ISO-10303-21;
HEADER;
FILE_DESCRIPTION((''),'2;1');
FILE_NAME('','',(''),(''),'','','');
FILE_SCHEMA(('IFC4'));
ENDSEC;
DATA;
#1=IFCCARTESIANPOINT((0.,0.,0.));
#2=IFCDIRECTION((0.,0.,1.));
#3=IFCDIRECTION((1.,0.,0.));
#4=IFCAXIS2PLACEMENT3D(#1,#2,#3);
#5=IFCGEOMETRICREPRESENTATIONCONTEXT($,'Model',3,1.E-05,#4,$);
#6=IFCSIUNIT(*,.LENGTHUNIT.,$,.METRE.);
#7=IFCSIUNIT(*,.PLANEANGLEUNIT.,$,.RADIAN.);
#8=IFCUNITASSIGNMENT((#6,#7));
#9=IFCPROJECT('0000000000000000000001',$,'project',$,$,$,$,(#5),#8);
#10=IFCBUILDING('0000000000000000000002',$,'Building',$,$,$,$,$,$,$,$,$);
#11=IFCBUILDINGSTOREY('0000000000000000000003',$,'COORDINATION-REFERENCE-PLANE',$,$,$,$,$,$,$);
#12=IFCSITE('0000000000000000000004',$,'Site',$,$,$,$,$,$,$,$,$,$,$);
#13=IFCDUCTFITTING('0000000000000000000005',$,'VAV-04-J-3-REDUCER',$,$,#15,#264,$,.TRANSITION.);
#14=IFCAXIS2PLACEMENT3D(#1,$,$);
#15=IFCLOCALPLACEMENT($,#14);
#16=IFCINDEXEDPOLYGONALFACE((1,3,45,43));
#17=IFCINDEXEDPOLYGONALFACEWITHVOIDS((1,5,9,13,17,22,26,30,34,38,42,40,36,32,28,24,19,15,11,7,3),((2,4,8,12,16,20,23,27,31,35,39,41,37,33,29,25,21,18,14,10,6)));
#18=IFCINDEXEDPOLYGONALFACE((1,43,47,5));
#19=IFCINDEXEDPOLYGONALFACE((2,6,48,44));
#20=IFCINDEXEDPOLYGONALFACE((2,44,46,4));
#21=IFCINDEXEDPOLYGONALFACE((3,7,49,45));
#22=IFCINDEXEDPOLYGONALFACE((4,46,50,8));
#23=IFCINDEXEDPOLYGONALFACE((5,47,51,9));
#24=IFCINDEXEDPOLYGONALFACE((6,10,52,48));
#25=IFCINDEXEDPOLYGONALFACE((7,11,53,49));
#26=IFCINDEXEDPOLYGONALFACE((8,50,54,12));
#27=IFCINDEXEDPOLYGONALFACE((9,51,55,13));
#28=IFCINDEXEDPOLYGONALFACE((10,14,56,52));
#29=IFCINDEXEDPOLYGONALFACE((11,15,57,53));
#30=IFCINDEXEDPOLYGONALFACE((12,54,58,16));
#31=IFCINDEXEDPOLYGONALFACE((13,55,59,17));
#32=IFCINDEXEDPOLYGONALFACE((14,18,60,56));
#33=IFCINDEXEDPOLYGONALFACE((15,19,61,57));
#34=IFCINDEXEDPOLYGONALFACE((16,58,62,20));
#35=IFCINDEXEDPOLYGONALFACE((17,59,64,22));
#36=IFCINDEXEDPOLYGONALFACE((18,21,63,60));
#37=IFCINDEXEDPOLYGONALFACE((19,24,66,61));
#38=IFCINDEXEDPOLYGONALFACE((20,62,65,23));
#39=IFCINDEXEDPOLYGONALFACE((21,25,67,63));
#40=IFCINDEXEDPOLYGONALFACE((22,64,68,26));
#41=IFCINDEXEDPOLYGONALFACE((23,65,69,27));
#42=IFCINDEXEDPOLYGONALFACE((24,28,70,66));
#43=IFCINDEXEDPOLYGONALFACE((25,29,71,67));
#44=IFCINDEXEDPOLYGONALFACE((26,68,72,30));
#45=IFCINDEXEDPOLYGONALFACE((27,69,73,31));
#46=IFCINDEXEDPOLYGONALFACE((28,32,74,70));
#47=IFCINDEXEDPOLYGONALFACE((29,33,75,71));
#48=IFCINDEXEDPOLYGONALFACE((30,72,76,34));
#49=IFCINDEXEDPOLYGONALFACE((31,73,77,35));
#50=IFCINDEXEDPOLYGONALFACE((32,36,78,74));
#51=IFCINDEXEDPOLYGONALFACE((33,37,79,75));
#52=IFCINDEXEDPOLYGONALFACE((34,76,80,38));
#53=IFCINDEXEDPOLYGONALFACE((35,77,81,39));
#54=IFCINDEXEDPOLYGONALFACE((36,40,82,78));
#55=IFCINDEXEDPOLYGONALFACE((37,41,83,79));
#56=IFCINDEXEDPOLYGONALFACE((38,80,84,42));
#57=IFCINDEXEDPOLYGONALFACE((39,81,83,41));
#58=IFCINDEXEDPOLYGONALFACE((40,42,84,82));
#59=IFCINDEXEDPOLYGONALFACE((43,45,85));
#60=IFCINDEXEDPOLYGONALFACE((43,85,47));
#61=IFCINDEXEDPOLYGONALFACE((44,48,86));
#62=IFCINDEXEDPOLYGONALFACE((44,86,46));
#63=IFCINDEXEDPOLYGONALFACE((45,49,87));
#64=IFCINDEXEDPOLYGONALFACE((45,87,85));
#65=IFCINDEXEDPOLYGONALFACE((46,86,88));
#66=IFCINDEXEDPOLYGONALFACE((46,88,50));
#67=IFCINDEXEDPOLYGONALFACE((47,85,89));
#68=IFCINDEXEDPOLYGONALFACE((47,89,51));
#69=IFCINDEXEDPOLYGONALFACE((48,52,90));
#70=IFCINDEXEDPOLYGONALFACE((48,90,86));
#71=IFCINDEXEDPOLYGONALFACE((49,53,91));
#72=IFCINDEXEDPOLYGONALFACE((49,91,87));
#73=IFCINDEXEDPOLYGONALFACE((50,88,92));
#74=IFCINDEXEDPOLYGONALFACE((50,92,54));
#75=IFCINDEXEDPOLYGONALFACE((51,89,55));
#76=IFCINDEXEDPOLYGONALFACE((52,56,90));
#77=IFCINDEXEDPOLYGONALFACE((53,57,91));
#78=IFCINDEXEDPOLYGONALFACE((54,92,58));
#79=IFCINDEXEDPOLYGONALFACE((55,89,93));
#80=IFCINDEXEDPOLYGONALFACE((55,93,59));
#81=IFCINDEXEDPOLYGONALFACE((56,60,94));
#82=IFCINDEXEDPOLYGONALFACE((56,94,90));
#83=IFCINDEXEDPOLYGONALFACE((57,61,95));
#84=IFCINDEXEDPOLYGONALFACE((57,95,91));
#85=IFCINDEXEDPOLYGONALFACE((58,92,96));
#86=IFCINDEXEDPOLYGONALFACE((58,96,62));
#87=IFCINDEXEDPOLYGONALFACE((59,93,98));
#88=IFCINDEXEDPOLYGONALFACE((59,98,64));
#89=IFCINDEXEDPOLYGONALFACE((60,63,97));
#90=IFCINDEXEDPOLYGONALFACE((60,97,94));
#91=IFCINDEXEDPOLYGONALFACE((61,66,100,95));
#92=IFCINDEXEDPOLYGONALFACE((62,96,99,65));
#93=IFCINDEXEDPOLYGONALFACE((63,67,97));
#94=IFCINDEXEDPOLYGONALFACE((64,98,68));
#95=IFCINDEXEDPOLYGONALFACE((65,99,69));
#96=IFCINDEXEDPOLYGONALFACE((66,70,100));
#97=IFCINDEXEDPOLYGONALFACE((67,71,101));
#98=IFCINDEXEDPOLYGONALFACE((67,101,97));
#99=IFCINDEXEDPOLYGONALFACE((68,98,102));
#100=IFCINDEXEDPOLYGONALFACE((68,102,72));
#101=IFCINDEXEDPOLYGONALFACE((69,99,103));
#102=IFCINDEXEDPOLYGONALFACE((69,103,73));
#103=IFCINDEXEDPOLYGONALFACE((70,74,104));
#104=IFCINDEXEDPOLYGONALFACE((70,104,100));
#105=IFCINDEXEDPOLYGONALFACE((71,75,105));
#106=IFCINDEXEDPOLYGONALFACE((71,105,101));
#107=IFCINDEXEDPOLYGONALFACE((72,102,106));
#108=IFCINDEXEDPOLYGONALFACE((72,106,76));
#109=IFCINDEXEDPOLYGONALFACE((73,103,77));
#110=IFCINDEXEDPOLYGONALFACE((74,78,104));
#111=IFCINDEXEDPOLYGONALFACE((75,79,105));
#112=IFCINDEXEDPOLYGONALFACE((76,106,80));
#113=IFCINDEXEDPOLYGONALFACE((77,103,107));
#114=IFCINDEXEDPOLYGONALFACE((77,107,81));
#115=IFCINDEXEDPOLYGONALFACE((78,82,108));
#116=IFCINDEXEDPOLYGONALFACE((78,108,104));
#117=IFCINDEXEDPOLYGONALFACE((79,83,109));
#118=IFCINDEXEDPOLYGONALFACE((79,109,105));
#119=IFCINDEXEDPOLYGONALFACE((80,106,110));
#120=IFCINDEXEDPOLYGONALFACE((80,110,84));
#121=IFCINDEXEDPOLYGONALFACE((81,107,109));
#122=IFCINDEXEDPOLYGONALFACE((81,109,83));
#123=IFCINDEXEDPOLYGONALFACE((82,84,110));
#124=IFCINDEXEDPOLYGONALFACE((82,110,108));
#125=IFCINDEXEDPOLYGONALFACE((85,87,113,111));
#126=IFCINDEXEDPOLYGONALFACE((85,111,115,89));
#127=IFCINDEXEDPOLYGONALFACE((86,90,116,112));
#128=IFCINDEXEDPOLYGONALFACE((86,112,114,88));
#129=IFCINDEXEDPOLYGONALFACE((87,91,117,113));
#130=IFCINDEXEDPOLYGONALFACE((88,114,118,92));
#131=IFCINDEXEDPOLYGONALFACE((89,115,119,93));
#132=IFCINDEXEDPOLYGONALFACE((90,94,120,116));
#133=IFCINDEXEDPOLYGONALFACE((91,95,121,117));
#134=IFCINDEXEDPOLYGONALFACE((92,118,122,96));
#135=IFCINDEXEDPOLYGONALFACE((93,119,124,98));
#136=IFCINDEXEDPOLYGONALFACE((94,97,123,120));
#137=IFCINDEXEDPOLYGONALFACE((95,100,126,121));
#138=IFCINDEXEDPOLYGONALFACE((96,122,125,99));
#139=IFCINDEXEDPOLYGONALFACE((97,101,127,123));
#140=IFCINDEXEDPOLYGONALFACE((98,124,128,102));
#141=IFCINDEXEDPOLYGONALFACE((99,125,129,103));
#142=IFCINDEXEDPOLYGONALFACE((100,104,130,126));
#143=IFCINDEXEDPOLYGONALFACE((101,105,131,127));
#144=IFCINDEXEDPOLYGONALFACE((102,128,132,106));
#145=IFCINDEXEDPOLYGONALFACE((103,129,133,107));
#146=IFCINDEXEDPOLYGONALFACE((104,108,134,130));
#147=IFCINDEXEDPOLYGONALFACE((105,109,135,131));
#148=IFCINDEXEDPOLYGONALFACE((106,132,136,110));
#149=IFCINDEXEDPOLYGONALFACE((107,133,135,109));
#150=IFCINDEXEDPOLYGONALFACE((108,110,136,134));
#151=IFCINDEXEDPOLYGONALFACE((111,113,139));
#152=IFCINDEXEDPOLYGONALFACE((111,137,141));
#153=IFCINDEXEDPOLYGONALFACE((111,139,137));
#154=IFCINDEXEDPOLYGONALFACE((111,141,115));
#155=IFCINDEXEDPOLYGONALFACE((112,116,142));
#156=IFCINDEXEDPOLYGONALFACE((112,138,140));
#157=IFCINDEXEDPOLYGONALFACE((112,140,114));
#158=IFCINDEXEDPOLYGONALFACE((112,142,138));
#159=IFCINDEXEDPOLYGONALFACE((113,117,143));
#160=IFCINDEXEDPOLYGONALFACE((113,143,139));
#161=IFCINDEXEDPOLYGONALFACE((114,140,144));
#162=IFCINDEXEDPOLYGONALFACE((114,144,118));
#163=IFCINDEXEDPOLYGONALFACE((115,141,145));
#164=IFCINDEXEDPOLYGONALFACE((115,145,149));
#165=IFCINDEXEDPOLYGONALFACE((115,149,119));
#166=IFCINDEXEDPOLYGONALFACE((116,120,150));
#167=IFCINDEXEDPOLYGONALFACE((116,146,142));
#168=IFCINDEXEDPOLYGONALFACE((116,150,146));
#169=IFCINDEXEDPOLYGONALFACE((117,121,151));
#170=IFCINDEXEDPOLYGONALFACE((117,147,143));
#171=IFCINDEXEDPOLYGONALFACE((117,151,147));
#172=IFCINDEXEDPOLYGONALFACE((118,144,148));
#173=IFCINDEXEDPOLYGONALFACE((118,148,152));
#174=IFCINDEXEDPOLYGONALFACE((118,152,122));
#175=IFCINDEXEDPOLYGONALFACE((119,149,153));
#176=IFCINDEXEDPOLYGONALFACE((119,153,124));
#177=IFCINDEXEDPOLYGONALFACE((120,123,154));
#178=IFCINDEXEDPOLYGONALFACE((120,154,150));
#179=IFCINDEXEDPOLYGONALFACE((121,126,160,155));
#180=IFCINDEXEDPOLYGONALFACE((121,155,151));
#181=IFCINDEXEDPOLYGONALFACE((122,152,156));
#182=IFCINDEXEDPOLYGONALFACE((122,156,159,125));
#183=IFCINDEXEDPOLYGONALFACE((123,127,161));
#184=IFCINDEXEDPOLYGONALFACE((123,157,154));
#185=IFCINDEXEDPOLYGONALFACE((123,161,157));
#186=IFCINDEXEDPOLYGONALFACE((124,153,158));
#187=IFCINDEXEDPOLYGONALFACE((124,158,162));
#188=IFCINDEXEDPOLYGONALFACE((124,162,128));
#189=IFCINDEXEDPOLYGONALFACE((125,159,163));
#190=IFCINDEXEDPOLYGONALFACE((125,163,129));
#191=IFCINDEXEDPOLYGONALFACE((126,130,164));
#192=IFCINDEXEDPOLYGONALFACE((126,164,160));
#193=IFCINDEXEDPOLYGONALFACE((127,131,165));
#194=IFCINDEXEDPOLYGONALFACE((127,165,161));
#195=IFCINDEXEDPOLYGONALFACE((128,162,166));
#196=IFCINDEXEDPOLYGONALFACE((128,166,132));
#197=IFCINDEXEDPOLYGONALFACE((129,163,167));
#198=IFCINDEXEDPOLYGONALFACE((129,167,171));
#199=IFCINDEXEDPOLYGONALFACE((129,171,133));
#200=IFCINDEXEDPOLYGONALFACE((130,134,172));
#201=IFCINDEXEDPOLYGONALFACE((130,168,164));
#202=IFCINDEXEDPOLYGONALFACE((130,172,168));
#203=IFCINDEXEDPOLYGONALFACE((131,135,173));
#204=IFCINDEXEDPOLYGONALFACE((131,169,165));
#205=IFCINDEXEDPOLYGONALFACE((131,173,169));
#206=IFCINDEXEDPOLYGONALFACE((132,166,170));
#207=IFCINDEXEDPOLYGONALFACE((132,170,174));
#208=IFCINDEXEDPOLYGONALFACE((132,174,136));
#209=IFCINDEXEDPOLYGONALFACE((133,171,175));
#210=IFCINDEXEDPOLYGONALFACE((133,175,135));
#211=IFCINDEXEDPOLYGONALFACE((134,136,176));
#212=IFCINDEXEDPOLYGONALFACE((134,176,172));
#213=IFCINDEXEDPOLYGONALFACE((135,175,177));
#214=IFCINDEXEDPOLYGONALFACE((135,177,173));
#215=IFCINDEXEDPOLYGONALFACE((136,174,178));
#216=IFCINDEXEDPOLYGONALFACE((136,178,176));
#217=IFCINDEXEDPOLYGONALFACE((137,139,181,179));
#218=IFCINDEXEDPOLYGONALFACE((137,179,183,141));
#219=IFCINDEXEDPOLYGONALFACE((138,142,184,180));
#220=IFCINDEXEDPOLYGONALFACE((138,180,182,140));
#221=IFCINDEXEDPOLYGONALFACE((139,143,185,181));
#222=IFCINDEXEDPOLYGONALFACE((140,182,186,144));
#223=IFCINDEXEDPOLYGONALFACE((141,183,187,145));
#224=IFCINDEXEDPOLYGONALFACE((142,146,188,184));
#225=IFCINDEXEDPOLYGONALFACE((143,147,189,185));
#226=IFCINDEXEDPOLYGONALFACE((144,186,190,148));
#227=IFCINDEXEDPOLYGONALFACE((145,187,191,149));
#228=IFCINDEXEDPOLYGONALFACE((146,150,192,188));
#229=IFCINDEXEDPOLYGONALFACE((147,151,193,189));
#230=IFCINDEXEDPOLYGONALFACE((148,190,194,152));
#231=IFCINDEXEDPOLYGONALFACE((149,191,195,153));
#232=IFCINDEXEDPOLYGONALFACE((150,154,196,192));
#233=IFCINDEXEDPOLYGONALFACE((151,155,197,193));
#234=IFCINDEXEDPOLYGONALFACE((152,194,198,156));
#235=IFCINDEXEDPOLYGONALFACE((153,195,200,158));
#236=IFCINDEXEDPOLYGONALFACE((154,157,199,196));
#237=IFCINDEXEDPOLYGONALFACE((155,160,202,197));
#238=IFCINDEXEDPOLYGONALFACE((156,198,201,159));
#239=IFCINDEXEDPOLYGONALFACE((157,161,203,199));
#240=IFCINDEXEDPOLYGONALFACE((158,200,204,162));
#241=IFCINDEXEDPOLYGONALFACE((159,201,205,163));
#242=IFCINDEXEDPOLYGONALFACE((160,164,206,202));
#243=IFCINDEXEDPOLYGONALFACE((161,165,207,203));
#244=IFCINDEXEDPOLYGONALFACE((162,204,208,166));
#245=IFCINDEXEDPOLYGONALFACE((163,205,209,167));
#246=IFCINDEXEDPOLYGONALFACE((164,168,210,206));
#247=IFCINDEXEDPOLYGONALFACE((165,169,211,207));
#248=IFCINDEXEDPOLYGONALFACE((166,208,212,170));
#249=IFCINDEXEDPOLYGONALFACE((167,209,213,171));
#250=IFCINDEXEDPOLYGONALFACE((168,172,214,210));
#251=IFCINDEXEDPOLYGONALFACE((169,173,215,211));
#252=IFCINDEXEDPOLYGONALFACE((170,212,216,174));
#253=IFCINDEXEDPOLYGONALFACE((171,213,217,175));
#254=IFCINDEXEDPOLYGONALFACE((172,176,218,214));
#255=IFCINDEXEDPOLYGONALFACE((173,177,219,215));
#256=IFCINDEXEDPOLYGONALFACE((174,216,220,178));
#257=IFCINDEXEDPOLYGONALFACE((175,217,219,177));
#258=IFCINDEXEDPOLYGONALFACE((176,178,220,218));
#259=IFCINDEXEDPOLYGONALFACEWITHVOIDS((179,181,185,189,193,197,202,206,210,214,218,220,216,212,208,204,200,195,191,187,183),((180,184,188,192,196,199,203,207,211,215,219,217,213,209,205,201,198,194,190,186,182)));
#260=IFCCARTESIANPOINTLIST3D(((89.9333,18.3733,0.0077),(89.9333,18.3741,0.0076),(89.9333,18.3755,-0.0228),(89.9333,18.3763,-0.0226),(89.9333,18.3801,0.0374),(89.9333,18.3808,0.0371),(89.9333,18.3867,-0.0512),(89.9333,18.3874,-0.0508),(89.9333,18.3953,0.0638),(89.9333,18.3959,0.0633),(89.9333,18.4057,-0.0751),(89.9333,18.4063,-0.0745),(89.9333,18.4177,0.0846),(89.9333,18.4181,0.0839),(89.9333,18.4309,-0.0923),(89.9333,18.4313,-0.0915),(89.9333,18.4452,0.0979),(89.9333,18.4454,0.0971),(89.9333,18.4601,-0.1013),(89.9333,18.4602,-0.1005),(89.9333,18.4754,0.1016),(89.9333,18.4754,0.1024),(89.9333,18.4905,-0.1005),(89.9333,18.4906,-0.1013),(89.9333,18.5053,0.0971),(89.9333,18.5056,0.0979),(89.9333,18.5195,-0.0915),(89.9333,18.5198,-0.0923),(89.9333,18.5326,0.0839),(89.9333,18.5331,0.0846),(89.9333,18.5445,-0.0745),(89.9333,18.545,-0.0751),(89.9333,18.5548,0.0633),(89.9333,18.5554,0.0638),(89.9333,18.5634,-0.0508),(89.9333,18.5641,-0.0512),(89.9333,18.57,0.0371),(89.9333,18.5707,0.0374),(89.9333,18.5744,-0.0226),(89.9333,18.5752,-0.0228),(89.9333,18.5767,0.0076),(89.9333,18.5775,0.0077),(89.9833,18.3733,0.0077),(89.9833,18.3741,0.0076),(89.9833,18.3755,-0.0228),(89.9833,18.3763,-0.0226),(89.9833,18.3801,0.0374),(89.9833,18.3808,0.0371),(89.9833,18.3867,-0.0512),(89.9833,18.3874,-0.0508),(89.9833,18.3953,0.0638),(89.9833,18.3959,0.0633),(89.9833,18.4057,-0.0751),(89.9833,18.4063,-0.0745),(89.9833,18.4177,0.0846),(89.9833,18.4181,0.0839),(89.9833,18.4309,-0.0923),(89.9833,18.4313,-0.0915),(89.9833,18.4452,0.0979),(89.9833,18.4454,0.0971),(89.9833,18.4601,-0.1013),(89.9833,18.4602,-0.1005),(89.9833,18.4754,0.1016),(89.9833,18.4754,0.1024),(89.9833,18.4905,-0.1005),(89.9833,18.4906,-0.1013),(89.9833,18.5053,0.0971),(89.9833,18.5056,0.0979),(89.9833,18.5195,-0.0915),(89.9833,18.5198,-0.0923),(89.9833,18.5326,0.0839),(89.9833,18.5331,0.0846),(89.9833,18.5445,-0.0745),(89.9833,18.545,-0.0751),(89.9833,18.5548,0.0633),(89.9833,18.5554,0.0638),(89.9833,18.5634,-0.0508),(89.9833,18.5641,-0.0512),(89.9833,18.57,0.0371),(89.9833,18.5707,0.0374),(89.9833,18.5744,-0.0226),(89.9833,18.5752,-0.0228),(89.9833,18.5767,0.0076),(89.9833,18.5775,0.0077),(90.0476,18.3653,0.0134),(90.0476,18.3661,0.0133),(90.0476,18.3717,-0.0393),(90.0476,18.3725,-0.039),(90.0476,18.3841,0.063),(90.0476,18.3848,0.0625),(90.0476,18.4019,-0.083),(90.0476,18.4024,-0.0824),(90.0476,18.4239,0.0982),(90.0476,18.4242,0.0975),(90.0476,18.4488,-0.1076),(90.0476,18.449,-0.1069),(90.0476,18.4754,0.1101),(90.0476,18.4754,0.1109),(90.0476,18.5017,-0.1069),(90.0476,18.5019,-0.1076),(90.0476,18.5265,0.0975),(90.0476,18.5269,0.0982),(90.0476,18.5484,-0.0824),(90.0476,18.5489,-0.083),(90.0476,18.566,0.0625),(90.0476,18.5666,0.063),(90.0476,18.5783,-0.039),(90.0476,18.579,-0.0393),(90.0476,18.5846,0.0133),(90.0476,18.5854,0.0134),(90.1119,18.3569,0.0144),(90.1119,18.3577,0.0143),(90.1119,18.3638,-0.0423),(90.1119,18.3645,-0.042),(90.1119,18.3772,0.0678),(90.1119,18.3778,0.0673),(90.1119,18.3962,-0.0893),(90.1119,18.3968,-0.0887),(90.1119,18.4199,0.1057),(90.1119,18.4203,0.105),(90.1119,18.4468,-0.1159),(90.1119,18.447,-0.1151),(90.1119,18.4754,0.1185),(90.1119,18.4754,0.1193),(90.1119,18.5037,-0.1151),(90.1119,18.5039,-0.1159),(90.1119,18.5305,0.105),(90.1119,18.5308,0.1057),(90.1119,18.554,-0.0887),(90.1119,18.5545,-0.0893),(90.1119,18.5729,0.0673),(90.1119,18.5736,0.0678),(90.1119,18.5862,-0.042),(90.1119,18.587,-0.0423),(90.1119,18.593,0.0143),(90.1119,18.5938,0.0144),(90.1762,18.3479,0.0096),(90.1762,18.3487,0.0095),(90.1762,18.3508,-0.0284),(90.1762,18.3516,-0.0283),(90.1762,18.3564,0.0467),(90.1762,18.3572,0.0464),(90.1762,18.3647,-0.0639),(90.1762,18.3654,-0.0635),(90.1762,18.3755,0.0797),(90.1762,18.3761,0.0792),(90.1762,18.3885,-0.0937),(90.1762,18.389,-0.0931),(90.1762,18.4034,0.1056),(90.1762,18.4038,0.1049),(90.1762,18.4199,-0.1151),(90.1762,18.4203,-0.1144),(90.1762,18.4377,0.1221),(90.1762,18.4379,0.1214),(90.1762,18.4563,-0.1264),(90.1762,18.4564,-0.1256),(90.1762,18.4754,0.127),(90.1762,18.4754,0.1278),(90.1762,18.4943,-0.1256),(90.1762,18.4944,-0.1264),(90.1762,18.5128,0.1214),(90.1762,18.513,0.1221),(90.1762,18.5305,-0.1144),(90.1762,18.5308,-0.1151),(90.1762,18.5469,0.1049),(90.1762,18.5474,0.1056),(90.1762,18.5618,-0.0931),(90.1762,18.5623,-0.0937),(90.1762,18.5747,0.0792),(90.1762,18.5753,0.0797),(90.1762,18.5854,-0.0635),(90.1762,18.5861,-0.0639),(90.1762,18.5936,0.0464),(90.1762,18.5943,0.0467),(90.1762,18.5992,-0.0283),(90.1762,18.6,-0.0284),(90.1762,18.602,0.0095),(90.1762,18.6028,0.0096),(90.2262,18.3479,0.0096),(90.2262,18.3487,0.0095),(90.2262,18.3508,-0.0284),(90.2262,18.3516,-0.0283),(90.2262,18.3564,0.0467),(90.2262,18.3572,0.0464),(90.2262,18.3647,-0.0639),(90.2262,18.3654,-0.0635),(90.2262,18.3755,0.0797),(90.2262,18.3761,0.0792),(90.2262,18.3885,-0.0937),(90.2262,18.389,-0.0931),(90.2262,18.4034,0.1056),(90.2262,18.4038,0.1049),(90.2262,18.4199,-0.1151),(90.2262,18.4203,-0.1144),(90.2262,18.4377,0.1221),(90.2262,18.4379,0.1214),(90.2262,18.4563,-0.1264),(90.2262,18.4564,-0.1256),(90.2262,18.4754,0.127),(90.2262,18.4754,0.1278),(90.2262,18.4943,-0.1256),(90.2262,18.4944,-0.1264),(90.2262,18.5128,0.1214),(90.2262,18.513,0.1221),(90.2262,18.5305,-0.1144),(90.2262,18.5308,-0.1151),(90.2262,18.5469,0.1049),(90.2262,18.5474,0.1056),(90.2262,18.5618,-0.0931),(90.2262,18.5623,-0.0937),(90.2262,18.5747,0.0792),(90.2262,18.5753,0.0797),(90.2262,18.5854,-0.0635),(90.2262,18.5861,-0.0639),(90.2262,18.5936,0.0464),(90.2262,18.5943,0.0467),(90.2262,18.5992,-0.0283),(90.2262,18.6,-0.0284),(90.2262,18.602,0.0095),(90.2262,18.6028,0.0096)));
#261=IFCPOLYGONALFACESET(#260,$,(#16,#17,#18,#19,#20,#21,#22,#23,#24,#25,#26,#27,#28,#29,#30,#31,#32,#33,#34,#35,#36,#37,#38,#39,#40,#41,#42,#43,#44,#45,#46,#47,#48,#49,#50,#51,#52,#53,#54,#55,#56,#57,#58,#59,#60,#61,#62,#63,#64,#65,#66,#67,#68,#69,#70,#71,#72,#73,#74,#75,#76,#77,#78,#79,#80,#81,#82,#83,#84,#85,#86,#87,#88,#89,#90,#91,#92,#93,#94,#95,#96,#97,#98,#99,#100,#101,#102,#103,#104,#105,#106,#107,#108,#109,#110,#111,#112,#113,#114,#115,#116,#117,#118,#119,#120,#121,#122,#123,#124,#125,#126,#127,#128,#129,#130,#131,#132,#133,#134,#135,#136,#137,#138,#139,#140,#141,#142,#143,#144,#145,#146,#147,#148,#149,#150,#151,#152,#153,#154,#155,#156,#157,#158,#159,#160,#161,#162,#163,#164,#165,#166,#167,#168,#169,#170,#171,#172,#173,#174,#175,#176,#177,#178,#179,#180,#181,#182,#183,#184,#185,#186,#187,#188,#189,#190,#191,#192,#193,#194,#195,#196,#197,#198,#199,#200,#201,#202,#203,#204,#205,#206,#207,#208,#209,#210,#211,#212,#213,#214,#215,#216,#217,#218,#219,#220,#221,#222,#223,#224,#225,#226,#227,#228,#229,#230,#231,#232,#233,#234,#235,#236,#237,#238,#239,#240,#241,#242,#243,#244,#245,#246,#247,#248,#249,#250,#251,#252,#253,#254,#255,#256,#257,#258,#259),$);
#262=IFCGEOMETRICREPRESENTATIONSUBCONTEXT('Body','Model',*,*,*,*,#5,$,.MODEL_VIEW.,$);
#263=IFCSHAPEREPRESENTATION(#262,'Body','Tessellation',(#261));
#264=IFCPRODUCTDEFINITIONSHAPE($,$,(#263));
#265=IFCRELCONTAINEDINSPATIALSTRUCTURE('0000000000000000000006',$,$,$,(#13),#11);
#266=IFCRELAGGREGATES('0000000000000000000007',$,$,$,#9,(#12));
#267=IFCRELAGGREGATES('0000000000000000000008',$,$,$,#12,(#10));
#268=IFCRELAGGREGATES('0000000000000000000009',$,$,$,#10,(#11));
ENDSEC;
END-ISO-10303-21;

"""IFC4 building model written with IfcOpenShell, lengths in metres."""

from ifc_helpers import new_model, entity, si_unit, frame, origin_with_axes, place, context, subcontext, project, spatial, element, save


model = new_model("IFC4")

# Units and contexts
model_context_1 = context("Model", 3, precision=1e-05, world=origin_with_axes())
body_context_1 = subcontext(model_context_1, "Body", "Model", "MODEL_VIEW")
ifc_project = project(units=[si_unit("LENGTHUNIT", "METRE"), si_unit("PLANEANGLEUNIT", "RADIAN")], contexts=[model_context_1])

# Site, building, storey
site = spatial("IfcSite", under=ifc_project, Name="Site")
building = spatial("IfcBuilding", under=site, Name="Building")
storey = spatial("IfcBuildingStorey", under=building, Name="COORDINATION-REFERENCE-PLANE")

# Duct fitting
for number, where, z_axis, x_axis, name in (
    (1, (90.2262, 18.4754, 0.0), (0.0, -1.0, 0.0), (0.0, 0.0, 1.0), "VAV-04-J-3-REDUCER"),
):
    element("IfcDuctFitting", number, at=place(None, frame(where, z_axis=z_axis, x_axis=x_axis)), inside=storey, Name=name, PredefinedType="TRANSITION", context=body_context_1, shape_type="SweptSolid", body=[
        entity("IfcRevolvedAreaSolid", entity("IfcArbitraryClosedProfileDef", "AREA", None, entity("IfcPolyline", [entity("IfcCartesianPoint", [0.1278, 0.0]), entity("IfcCartesianPoint", [0.1278, 0.05]), entity("IfcCartesianPoint", [0.1024, 0.2429]), entity("IfcCartesianPoint", [0.1024, 0.2929]), entity("IfcCartesianPoint", [0.1016, 0.2929]), entity("IfcCartesianPoint", [0.1016, 0.2429]), entity("IfcCartesianPoint", [0.127, 0.05]), entity("IfcCartesianPoint", [0.127, 0.0]), entity("IfcCartesianPoint", [0.1278, 0.0])])), entity("IfcAxis2Placement3D", entity("IfcCartesianPoint", [0.0, 0.0, 0.0])), entity("IfcAxis1Placement", entity("IfcCartesianPoint", [0.0, 0.0, 0.0]), entity("IfcDirection", [0.0, 1.0, 0.0])), 6.283185),
    ])

save(model, "model.ifc")
